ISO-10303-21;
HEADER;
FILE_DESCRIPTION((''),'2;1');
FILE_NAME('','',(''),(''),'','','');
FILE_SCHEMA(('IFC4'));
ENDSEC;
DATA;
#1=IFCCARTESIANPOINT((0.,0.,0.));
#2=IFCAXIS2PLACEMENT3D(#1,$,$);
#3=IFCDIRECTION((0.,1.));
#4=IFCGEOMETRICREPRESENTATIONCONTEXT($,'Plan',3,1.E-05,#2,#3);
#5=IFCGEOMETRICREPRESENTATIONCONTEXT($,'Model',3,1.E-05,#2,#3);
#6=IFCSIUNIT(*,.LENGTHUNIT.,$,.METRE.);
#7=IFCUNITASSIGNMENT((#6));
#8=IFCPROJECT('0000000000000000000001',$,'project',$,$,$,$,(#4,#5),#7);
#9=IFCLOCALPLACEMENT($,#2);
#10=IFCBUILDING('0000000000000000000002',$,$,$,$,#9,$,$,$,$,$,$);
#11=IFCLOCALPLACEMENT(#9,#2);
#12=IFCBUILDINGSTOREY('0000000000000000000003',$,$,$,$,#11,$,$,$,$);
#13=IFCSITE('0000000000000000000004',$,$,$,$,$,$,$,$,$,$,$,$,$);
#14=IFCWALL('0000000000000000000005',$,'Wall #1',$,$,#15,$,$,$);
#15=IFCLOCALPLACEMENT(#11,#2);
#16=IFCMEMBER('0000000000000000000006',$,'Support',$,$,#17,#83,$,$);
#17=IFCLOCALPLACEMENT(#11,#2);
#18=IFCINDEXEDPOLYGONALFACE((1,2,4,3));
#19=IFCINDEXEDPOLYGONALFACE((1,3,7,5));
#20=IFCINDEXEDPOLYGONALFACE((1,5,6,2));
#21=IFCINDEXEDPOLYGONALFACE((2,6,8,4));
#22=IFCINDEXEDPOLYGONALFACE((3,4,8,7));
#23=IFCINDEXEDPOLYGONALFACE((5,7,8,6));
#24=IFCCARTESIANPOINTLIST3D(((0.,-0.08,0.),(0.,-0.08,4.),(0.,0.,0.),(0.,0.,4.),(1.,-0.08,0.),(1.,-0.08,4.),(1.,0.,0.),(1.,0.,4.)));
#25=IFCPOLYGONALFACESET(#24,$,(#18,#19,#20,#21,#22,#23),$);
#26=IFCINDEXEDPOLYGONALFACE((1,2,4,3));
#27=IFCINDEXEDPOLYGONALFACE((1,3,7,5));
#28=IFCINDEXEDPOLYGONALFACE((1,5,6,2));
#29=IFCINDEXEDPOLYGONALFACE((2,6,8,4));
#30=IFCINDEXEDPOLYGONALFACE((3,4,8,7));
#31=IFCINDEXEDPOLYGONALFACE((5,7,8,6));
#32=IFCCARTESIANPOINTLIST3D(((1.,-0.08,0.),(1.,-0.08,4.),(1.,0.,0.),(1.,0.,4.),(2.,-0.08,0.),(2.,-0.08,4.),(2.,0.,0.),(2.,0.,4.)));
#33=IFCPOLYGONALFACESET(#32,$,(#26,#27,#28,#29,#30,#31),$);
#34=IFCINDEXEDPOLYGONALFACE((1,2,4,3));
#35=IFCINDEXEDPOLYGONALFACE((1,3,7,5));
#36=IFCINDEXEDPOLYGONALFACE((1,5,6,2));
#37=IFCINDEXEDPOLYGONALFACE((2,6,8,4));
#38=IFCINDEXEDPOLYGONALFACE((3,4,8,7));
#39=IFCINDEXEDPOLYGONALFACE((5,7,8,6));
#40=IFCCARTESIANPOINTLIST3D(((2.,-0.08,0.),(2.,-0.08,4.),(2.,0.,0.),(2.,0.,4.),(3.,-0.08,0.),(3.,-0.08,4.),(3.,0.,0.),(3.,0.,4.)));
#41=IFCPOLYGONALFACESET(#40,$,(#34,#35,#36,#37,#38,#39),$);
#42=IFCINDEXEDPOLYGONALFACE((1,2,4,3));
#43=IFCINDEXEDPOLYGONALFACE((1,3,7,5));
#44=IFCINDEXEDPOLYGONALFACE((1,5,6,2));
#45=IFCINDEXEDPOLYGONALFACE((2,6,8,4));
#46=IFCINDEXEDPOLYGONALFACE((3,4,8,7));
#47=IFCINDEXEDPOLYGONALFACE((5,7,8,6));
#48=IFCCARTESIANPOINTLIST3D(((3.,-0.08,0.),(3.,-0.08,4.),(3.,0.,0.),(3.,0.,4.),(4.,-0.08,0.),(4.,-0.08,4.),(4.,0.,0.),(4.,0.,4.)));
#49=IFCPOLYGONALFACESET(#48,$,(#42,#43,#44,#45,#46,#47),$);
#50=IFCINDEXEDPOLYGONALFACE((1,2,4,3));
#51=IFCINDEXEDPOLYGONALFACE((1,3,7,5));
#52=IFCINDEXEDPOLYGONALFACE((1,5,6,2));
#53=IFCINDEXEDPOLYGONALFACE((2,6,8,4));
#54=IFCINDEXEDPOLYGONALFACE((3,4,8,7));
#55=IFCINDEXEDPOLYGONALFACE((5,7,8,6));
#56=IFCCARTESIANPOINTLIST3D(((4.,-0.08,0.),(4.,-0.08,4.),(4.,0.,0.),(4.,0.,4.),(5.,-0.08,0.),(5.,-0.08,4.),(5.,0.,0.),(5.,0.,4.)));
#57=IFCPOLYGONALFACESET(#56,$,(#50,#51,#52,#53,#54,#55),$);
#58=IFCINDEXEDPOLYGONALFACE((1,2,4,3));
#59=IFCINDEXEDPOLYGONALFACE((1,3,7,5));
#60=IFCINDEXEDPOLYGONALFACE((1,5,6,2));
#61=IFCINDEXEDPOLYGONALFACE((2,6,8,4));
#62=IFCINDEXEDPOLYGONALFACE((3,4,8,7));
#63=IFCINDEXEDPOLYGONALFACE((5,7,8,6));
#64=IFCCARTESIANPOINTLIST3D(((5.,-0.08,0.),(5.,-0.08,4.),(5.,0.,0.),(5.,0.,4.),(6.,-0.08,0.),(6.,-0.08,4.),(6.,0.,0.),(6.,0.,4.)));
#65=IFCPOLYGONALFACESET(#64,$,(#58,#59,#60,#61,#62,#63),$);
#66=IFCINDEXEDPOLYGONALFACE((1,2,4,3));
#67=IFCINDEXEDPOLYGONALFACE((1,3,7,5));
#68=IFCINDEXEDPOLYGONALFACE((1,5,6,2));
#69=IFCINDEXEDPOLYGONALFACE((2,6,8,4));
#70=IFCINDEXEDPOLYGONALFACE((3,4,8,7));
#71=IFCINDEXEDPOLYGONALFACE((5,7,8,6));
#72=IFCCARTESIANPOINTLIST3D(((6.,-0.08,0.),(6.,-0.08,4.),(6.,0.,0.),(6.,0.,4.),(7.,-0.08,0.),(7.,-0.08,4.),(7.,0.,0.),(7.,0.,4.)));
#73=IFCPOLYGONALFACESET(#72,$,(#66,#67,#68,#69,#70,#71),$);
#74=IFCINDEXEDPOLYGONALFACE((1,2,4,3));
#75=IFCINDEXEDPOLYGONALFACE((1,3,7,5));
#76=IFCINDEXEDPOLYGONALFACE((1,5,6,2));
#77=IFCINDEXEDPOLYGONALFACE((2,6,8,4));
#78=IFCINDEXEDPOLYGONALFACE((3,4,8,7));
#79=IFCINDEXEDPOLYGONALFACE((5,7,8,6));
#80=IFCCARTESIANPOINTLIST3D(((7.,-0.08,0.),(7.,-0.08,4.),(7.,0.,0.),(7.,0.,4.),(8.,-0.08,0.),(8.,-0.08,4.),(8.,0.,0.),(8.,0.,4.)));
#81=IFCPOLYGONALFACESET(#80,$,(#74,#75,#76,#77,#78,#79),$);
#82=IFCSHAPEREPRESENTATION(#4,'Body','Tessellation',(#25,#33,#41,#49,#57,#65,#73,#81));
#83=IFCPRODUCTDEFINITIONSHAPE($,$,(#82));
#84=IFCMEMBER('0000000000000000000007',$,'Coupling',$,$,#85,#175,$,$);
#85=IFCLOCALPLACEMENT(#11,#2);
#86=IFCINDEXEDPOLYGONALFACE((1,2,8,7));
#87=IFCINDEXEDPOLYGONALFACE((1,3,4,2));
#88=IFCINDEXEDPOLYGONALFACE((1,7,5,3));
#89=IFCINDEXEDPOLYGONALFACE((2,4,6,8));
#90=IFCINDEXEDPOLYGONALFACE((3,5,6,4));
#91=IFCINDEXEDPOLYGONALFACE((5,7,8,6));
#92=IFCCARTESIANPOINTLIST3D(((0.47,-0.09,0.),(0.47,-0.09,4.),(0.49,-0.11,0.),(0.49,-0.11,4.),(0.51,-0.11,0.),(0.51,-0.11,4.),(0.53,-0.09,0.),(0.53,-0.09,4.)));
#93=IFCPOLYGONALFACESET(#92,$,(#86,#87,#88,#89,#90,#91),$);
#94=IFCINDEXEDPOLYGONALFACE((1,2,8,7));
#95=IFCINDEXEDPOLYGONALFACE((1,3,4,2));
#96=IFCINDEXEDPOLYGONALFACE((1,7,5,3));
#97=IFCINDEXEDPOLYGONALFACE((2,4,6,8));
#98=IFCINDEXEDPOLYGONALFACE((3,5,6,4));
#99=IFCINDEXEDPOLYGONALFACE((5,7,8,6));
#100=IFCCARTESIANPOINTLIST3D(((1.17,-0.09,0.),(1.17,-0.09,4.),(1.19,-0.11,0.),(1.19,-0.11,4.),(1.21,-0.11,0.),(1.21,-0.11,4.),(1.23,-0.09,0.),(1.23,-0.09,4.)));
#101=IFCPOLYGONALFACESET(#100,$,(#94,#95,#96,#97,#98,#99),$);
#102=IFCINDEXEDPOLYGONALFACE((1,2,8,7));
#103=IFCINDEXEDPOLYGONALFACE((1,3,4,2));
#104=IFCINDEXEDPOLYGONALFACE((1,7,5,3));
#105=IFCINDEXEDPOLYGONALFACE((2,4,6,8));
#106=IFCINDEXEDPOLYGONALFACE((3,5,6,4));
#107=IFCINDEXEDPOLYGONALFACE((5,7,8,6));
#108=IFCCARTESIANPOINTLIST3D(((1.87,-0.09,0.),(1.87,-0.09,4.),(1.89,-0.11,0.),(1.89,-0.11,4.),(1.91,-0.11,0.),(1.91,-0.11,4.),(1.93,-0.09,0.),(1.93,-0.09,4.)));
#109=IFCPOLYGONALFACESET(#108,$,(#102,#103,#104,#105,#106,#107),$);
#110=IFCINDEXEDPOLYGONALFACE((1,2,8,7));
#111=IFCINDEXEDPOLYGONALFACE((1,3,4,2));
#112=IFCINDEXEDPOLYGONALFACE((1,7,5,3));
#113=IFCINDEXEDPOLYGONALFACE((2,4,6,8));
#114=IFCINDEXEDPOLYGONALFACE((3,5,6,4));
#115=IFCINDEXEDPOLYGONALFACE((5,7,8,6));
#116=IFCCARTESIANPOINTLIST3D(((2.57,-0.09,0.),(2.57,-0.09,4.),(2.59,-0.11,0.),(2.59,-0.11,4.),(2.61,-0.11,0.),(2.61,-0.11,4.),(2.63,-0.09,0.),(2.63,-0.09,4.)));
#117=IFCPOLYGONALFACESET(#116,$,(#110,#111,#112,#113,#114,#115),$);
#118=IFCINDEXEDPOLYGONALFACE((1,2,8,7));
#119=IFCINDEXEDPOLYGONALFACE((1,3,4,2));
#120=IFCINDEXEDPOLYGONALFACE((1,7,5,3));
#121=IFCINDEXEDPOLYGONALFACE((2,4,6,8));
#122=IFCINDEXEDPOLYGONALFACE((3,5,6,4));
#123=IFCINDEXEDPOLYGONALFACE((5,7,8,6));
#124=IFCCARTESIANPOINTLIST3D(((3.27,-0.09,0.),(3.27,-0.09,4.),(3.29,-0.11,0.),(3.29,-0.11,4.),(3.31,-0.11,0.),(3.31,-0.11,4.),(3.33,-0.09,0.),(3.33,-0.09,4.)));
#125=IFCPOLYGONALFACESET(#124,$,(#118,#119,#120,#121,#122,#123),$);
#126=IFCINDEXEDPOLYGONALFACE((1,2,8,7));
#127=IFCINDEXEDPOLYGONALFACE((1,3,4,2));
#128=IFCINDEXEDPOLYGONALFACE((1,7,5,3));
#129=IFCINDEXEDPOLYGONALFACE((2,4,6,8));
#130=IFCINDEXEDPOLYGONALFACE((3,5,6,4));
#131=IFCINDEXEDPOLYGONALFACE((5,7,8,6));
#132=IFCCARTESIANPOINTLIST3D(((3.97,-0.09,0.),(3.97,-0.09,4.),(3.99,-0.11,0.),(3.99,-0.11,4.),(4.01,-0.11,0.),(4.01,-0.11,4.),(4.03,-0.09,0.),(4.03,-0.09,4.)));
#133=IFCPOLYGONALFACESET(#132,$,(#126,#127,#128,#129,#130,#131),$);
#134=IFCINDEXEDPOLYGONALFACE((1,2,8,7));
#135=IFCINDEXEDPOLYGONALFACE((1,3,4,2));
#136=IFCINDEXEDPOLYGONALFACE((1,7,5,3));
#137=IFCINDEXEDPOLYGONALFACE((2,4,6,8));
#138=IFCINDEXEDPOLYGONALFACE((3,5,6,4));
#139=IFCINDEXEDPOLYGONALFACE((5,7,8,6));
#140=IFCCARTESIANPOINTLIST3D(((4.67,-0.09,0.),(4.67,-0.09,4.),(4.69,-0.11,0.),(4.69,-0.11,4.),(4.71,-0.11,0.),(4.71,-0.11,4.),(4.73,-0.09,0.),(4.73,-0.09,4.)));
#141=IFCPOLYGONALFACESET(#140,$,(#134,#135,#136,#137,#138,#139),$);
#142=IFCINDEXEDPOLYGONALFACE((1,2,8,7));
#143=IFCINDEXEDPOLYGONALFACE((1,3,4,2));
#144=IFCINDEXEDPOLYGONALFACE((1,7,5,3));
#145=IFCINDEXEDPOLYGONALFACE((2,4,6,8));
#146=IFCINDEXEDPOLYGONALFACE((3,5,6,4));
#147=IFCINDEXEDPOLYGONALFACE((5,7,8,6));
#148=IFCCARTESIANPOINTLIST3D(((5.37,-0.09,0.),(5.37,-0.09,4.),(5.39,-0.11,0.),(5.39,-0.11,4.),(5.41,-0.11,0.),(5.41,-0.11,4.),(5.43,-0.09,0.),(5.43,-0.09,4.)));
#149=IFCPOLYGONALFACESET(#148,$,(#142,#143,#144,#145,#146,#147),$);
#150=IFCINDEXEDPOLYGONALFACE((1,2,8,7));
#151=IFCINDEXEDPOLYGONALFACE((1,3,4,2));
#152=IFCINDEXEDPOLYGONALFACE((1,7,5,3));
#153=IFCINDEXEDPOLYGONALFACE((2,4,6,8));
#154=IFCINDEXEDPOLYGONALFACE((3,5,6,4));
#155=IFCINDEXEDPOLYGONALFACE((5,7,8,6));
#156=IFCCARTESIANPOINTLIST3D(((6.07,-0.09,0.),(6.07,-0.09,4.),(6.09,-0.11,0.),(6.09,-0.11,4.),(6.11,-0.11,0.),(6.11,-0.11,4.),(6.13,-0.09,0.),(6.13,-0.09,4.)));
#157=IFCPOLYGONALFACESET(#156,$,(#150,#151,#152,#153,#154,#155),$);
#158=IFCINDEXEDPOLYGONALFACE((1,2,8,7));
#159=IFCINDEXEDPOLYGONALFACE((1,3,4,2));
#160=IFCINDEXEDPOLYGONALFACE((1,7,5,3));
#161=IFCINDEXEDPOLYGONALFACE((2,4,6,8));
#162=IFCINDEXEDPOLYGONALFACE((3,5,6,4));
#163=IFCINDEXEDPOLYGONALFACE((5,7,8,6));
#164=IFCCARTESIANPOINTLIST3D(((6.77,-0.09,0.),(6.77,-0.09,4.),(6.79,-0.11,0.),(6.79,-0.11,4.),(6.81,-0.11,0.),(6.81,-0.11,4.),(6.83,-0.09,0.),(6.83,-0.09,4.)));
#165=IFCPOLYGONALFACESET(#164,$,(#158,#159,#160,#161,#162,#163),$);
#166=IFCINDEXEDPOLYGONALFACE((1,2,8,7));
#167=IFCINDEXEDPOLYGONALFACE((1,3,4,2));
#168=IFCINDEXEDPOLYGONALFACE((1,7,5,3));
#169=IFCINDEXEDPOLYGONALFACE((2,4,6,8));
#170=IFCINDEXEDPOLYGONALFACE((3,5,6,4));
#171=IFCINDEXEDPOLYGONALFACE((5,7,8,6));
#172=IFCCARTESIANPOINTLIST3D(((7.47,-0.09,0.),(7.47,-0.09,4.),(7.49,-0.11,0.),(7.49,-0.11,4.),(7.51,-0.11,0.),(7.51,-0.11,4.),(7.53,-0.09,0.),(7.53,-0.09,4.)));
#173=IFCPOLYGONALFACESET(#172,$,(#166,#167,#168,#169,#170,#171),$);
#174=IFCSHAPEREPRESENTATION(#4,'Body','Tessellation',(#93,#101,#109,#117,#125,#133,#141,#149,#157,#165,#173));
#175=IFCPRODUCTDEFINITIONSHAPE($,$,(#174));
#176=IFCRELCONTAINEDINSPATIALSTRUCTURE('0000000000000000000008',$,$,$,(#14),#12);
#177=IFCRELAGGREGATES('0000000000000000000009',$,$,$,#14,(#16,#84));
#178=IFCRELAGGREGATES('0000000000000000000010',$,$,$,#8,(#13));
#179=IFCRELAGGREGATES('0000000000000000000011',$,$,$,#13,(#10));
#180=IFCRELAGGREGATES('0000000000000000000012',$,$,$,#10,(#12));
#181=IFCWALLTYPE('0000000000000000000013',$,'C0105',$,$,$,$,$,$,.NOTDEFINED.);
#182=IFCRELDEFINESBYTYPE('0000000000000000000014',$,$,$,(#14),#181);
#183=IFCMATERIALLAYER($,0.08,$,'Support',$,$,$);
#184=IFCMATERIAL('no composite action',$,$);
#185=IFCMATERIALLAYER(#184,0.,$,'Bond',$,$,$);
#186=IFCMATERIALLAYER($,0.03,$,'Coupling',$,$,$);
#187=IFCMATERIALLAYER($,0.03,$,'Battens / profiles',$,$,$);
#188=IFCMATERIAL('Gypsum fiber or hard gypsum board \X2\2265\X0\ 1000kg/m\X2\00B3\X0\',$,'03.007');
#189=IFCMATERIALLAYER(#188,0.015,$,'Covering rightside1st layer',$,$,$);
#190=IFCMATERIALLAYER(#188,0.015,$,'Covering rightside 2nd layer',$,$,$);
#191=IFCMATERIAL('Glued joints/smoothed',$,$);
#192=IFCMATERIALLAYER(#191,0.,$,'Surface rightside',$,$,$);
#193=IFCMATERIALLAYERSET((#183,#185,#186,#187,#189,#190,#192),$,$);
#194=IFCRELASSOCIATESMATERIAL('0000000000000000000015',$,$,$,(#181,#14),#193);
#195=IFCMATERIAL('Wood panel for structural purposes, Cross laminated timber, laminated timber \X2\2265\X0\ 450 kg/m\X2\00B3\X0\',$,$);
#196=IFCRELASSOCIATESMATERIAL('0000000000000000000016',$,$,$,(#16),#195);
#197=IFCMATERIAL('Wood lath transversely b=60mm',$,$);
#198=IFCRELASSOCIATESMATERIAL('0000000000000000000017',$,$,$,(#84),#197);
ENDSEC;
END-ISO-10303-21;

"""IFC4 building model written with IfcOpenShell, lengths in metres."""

from ifc_helpers import new_model, si_unit, direction, frame, frame_2d, origin, place, context, project, spatial, polyline, rectangle, outline, extrude, material, layer, layer_set, type_object, element, aggregate, save


model = new_model("IFC4")

# Units and contexts
plan_context = context("Plan", 3, precision=1e-05, world=origin(), true_north=direction((0.0, 1.0)))
model_context = context("Model", 3, precision=1e-05, world=origin(), true_north=direction((0.0, 1.0)))
ifc_project = project(units=[si_unit("LENGTHUNIT", "METRE")], contexts=[plan_context, model_context])

# Site, building, storey
site = spatial("IfcSite", under=ifc_project)
building_placement = place(None, origin())
building = spatial("IfcBuilding", under=site, at=building_placement)
storey_placement = place(building_placement, origin())
storey = spatial("IfcBuildingStorey", under=building, at=storey_placement)

# Wall, members
ifc_layer_1 = layer(None, 0.08, Name="Support")
ifc_material_1 = material(Name="no composite action")
ifc_layer_2 = layer(ifc_material_1, 0.0, Name="Bond")
ifc_layer_3 = layer(None, 0.03, Name="Coupling")
ifc_layer_4 = layer(None, 0.03, Name="Battens / profiles")
ifc_material_2 = material(Name="Gypsum fiber or hard gypsum board ≥ 1000kg/m³", Category="03.007")
ifc_layer_5 = layer(ifc_material_2, 0.015, Name="Covering rightside1st layer")
ifc_layer_6 = layer(ifc_material_2, 0.015, Name="Covering rightside 2nd layer")
ifc_material_3 = material(Name="Glued joints/smoothed")
ifc_layer_7 = layer(ifc_material_3, 0.0, Name="Surface rightside")
ifc_layer_set = layer_set([ifc_layer_1, ifc_layer_2, ifc_layer_3, ifc_layer_4, ifc_layer_5, ifc_layer_6, ifc_layer_7])
wall_type = type_object("IfcWallType", Name="C0105", PredefinedType="NOTDEFINED", material=ifc_layer_set)
wall_placement = place(None, frame((0.0, 0.0, 0.0), z_axis=(0.0, -1.0, 0.0), x_axis=(1.0, 0.0, 0.0)))
wall = element("IfcWall", 1, at=wall_placement, inside=storey, type_object=wall_type, material=ifc_layer_set, Name="Wall #1")
ifc_material_4 = material(Name="Wood panel for structural purposes, Cross laminated timber, laminated timber ≥ 450 kg/m³")
member_1_placement = place(wall_placement, origin())
member_1 = element("IfcMember", 2, at=member_1_placement, material=ifc_material_4, Name="Support", context=plan_context, shape_type="SweptSolid", body=[
    extrude(rectangle(XDim=1.0, YDim=0.08, at=frame_2d((0.5, 0.04), x_axis=(1.0, 0.0))), frame((0.0, 4.0, 0.0), z_axis=(0.0, -1.0, 0.0), x_axis=(1.0, 0.0, 0.0)), (0.0, 0.0, 1.0), 4.0),
    extrude(rectangle(XDim=1.0, YDim=0.08, at=frame_2d((0.5, 0.04), x_axis=(1.0, 0.0))), frame((1.0, 4.0, 0.0), z_axis=(0.0, -1.0, 0.0), x_axis=(1.0, 0.0, 0.0)), (0.0, 0.0, 1.0), 4.0),
    extrude(rectangle(XDim=1.0, YDim=0.08, at=frame_2d((0.5, 0.04), x_axis=(1.0, 0.0))), frame((2.0, 4.0, 0.0), z_axis=(0.0, -1.0, 0.0), x_axis=(1.0, 0.0, 0.0)), (0.0, 0.0, 1.0), 4.0),
    extrude(rectangle(XDim=1.0, YDim=0.08, at=frame_2d((0.5, 0.04), x_axis=(1.0, 0.0))), frame((3.0, 4.0, 0.0), z_axis=(0.0, -1.0, 0.0), x_axis=(1.0, 0.0, 0.0)), (0.0, 0.0, 1.0), 4.0),
    extrude(rectangle(XDim=1.0, YDim=0.08, at=frame_2d((0.5, 0.04), x_axis=(1.0, 0.0))), frame((4.0, 4.0, 0.0), z_axis=(0.0, -1.0, 0.0), x_axis=(1.0, 0.0, 0.0)), (0.0, 0.0, 1.0), 4.0),
    extrude(rectangle(XDim=1.0, YDim=0.08, at=frame_2d((0.5, 0.04), x_axis=(1.0, 0.0))), frame((5.0, 4.0, 0.0), z_axis=(0.0, -1.0, 0.0), x_axis=(1.0, 0.0, 0.0)), (0.0, 0.0, 1.0), 4.0),
    extrude(rectangle(XDim=1.0, YDim=0.08, at=frame_2d((0.5, 0.04), x_axis=(1.0, 0.0))), frame((6.0, 4.0, 0.0), z_axis=(0.0, -1.0, 0.0), x_axis=(1.0, 0.0, 0.0)), (0.0, 0.0, 1.0), 4.0),
    extrude(rectangle(XDim=1.0, YDim=0.08, at=frame_2d((0.5, 0.04), x_axis=(1.0, 0.0))), frame((7.0, 4.0, 0.0), z_axis=(0.0, -1.0, 0.0), x_axis=(1.0, 0.0, 0.0)), (0.0, 0.0, 1.0), 4.0),
])
ifc_material_5 = material(Name="Wood lath transversely b=60mm")
member_2_placement = place(wall_placement, origin())
member_2 = element("IfcMember", 3, at=member_2_placement, material=ifc_material_5, Name="Coupling", context=plan_context, shape_type="SweptSolid", body=[
    extrude(outline(polyline([(0.0, 0.0), (0.06, 0.0), (0.04, 0.02), (0.02, 0.02), (0.0, 0.0)])), frame((0.47, 4.0, 0.09), z_axis=(0.0, -1.0, 0.0), x_axis=(1.0, 0.0, 0.0)), (0.0, 0.0, 1.0), 4.0),
    extrude(outline(polyline([(0.0, 0.0), (0.06, 0.0), (0.04, 0.02), (0.02, 0.02), (0.0, 0.0)])), frame((1.17, 4.0, 0.09), z_axis=(0.0, -1.0, 0.0), x_axis=(1.0, 0.0, 0.0)), (0.0, 0.0, 1.0), 4.0),
    extrude(outline(polyline([(0.0, 0.0), (0.06, 0.0), (0.04, 0.02), (0.02, 0.02), (0.0, 0.0)])), frame((1.87, 4.0, 0.09), z_axis=(0.0, -1.0, 0.0), x_axis=(1.0, 0.0, 0.0)), (0.0, 0.0, 1.0), 4.0),
    extrude(outline(polyline([(0.0, 0.0), (0.06, 0.0), (0.04, 0.02), (0.02, 0.02), (0.0, 0.0)])), frame((2.57, 4.0, 0.09), z_axis=(0.0, -1.0, 0.0), x_axis=(1.0, 0.0, 0.0)), (0.0, 0.0, 1.0), 4.0),
    extrude(outline(polyline([(0.0, 0.0), (0.06, 0.0), (0.04, 0.02), (0.02, 0.02), (0.0, 0.0)])), frame((3.27, 4.0, 0.09), z_axis=(0.0, -1.0, 0.0), x_axis=(1.0, 0.0, 0.0)), (0.0, 0.0, 1.0), 4.0),
    extrude(outline(polyline([(0.0, 0.0), (0.06, 0.0), (0.04, 0.02), (0.02, 0.02), (0.0, 0.0)])), frame((3.97, 4.0, 0.09), z_axis=(0.0, -1.0, 0.0), x_axis=(1.0, 0.0, 0.0)), (0.0, 0.0, 1.0), 4.0),
    extrude(outline(polyline([(0.0, 0.0), (0.06, 0.0), (0.04, 0.02), (0.02, 0.02), (0.0, 0.0)])), frame((4.67, 4.0, 0.09), z_axis=(0.0, -1.0, 0.0), x_axis=(1.0, 0.0, 0.0)), (0.0, 0.0, 1.0), 4.0),
    extrude(outline(polyline([(0.0, 0.0), (0.06, 0.0), (0.04, 0.02), (0.02, 0.02), (0.0, 0.0)])), frame((5.37, 4.0, 0.09), z_axis=(0.0, -1.0, 0.0), x_axis=(1.0, 0.0, 0.0)), (0.0, 0.0, 1.0), 4.0),
    extrude(outline(polyline([(0.0, 0.0), (0.06, 0.0), (0.04, 0.02), (0.02, 0.02), (0.0, 0.0)])), frame((6.07, 4.0, 0.09), z_axis=(0.0, -1.0, 0.0), x_axis=(1.0, 0.0, 0.0)), (0.0, 0.0, 1.0), 4.0),
    extrude(outline(polyline([(0.0, 0.0), (0.06, 0.0), (0.04, 0.02), (0.02, 0.02), (0.0, 0.0)])), frame((6.77, 4.0, 0.09), z_axis=(0.0, -1.0, 0.0), x_axis=(1.0, 0.0, 0.0)), (0.0, 0.0, 1.0), 4.0),
    extrude(outline(polyline([(0.0, 0.0), (0.06, 0.0), (0.04, 0.02), (0.02, 0.02), (0.0, 0.0)])), frame((7.47, 4.0, 0.09), z_axis=(0.0, -1.0, 0.0), x_axis=(1.0, 0.0, 0.0)), (0.0, 0.0, 1.0), 4.0),
])
aggregate(wall, [member_1, member_2])

save(model, "model.ifc")
